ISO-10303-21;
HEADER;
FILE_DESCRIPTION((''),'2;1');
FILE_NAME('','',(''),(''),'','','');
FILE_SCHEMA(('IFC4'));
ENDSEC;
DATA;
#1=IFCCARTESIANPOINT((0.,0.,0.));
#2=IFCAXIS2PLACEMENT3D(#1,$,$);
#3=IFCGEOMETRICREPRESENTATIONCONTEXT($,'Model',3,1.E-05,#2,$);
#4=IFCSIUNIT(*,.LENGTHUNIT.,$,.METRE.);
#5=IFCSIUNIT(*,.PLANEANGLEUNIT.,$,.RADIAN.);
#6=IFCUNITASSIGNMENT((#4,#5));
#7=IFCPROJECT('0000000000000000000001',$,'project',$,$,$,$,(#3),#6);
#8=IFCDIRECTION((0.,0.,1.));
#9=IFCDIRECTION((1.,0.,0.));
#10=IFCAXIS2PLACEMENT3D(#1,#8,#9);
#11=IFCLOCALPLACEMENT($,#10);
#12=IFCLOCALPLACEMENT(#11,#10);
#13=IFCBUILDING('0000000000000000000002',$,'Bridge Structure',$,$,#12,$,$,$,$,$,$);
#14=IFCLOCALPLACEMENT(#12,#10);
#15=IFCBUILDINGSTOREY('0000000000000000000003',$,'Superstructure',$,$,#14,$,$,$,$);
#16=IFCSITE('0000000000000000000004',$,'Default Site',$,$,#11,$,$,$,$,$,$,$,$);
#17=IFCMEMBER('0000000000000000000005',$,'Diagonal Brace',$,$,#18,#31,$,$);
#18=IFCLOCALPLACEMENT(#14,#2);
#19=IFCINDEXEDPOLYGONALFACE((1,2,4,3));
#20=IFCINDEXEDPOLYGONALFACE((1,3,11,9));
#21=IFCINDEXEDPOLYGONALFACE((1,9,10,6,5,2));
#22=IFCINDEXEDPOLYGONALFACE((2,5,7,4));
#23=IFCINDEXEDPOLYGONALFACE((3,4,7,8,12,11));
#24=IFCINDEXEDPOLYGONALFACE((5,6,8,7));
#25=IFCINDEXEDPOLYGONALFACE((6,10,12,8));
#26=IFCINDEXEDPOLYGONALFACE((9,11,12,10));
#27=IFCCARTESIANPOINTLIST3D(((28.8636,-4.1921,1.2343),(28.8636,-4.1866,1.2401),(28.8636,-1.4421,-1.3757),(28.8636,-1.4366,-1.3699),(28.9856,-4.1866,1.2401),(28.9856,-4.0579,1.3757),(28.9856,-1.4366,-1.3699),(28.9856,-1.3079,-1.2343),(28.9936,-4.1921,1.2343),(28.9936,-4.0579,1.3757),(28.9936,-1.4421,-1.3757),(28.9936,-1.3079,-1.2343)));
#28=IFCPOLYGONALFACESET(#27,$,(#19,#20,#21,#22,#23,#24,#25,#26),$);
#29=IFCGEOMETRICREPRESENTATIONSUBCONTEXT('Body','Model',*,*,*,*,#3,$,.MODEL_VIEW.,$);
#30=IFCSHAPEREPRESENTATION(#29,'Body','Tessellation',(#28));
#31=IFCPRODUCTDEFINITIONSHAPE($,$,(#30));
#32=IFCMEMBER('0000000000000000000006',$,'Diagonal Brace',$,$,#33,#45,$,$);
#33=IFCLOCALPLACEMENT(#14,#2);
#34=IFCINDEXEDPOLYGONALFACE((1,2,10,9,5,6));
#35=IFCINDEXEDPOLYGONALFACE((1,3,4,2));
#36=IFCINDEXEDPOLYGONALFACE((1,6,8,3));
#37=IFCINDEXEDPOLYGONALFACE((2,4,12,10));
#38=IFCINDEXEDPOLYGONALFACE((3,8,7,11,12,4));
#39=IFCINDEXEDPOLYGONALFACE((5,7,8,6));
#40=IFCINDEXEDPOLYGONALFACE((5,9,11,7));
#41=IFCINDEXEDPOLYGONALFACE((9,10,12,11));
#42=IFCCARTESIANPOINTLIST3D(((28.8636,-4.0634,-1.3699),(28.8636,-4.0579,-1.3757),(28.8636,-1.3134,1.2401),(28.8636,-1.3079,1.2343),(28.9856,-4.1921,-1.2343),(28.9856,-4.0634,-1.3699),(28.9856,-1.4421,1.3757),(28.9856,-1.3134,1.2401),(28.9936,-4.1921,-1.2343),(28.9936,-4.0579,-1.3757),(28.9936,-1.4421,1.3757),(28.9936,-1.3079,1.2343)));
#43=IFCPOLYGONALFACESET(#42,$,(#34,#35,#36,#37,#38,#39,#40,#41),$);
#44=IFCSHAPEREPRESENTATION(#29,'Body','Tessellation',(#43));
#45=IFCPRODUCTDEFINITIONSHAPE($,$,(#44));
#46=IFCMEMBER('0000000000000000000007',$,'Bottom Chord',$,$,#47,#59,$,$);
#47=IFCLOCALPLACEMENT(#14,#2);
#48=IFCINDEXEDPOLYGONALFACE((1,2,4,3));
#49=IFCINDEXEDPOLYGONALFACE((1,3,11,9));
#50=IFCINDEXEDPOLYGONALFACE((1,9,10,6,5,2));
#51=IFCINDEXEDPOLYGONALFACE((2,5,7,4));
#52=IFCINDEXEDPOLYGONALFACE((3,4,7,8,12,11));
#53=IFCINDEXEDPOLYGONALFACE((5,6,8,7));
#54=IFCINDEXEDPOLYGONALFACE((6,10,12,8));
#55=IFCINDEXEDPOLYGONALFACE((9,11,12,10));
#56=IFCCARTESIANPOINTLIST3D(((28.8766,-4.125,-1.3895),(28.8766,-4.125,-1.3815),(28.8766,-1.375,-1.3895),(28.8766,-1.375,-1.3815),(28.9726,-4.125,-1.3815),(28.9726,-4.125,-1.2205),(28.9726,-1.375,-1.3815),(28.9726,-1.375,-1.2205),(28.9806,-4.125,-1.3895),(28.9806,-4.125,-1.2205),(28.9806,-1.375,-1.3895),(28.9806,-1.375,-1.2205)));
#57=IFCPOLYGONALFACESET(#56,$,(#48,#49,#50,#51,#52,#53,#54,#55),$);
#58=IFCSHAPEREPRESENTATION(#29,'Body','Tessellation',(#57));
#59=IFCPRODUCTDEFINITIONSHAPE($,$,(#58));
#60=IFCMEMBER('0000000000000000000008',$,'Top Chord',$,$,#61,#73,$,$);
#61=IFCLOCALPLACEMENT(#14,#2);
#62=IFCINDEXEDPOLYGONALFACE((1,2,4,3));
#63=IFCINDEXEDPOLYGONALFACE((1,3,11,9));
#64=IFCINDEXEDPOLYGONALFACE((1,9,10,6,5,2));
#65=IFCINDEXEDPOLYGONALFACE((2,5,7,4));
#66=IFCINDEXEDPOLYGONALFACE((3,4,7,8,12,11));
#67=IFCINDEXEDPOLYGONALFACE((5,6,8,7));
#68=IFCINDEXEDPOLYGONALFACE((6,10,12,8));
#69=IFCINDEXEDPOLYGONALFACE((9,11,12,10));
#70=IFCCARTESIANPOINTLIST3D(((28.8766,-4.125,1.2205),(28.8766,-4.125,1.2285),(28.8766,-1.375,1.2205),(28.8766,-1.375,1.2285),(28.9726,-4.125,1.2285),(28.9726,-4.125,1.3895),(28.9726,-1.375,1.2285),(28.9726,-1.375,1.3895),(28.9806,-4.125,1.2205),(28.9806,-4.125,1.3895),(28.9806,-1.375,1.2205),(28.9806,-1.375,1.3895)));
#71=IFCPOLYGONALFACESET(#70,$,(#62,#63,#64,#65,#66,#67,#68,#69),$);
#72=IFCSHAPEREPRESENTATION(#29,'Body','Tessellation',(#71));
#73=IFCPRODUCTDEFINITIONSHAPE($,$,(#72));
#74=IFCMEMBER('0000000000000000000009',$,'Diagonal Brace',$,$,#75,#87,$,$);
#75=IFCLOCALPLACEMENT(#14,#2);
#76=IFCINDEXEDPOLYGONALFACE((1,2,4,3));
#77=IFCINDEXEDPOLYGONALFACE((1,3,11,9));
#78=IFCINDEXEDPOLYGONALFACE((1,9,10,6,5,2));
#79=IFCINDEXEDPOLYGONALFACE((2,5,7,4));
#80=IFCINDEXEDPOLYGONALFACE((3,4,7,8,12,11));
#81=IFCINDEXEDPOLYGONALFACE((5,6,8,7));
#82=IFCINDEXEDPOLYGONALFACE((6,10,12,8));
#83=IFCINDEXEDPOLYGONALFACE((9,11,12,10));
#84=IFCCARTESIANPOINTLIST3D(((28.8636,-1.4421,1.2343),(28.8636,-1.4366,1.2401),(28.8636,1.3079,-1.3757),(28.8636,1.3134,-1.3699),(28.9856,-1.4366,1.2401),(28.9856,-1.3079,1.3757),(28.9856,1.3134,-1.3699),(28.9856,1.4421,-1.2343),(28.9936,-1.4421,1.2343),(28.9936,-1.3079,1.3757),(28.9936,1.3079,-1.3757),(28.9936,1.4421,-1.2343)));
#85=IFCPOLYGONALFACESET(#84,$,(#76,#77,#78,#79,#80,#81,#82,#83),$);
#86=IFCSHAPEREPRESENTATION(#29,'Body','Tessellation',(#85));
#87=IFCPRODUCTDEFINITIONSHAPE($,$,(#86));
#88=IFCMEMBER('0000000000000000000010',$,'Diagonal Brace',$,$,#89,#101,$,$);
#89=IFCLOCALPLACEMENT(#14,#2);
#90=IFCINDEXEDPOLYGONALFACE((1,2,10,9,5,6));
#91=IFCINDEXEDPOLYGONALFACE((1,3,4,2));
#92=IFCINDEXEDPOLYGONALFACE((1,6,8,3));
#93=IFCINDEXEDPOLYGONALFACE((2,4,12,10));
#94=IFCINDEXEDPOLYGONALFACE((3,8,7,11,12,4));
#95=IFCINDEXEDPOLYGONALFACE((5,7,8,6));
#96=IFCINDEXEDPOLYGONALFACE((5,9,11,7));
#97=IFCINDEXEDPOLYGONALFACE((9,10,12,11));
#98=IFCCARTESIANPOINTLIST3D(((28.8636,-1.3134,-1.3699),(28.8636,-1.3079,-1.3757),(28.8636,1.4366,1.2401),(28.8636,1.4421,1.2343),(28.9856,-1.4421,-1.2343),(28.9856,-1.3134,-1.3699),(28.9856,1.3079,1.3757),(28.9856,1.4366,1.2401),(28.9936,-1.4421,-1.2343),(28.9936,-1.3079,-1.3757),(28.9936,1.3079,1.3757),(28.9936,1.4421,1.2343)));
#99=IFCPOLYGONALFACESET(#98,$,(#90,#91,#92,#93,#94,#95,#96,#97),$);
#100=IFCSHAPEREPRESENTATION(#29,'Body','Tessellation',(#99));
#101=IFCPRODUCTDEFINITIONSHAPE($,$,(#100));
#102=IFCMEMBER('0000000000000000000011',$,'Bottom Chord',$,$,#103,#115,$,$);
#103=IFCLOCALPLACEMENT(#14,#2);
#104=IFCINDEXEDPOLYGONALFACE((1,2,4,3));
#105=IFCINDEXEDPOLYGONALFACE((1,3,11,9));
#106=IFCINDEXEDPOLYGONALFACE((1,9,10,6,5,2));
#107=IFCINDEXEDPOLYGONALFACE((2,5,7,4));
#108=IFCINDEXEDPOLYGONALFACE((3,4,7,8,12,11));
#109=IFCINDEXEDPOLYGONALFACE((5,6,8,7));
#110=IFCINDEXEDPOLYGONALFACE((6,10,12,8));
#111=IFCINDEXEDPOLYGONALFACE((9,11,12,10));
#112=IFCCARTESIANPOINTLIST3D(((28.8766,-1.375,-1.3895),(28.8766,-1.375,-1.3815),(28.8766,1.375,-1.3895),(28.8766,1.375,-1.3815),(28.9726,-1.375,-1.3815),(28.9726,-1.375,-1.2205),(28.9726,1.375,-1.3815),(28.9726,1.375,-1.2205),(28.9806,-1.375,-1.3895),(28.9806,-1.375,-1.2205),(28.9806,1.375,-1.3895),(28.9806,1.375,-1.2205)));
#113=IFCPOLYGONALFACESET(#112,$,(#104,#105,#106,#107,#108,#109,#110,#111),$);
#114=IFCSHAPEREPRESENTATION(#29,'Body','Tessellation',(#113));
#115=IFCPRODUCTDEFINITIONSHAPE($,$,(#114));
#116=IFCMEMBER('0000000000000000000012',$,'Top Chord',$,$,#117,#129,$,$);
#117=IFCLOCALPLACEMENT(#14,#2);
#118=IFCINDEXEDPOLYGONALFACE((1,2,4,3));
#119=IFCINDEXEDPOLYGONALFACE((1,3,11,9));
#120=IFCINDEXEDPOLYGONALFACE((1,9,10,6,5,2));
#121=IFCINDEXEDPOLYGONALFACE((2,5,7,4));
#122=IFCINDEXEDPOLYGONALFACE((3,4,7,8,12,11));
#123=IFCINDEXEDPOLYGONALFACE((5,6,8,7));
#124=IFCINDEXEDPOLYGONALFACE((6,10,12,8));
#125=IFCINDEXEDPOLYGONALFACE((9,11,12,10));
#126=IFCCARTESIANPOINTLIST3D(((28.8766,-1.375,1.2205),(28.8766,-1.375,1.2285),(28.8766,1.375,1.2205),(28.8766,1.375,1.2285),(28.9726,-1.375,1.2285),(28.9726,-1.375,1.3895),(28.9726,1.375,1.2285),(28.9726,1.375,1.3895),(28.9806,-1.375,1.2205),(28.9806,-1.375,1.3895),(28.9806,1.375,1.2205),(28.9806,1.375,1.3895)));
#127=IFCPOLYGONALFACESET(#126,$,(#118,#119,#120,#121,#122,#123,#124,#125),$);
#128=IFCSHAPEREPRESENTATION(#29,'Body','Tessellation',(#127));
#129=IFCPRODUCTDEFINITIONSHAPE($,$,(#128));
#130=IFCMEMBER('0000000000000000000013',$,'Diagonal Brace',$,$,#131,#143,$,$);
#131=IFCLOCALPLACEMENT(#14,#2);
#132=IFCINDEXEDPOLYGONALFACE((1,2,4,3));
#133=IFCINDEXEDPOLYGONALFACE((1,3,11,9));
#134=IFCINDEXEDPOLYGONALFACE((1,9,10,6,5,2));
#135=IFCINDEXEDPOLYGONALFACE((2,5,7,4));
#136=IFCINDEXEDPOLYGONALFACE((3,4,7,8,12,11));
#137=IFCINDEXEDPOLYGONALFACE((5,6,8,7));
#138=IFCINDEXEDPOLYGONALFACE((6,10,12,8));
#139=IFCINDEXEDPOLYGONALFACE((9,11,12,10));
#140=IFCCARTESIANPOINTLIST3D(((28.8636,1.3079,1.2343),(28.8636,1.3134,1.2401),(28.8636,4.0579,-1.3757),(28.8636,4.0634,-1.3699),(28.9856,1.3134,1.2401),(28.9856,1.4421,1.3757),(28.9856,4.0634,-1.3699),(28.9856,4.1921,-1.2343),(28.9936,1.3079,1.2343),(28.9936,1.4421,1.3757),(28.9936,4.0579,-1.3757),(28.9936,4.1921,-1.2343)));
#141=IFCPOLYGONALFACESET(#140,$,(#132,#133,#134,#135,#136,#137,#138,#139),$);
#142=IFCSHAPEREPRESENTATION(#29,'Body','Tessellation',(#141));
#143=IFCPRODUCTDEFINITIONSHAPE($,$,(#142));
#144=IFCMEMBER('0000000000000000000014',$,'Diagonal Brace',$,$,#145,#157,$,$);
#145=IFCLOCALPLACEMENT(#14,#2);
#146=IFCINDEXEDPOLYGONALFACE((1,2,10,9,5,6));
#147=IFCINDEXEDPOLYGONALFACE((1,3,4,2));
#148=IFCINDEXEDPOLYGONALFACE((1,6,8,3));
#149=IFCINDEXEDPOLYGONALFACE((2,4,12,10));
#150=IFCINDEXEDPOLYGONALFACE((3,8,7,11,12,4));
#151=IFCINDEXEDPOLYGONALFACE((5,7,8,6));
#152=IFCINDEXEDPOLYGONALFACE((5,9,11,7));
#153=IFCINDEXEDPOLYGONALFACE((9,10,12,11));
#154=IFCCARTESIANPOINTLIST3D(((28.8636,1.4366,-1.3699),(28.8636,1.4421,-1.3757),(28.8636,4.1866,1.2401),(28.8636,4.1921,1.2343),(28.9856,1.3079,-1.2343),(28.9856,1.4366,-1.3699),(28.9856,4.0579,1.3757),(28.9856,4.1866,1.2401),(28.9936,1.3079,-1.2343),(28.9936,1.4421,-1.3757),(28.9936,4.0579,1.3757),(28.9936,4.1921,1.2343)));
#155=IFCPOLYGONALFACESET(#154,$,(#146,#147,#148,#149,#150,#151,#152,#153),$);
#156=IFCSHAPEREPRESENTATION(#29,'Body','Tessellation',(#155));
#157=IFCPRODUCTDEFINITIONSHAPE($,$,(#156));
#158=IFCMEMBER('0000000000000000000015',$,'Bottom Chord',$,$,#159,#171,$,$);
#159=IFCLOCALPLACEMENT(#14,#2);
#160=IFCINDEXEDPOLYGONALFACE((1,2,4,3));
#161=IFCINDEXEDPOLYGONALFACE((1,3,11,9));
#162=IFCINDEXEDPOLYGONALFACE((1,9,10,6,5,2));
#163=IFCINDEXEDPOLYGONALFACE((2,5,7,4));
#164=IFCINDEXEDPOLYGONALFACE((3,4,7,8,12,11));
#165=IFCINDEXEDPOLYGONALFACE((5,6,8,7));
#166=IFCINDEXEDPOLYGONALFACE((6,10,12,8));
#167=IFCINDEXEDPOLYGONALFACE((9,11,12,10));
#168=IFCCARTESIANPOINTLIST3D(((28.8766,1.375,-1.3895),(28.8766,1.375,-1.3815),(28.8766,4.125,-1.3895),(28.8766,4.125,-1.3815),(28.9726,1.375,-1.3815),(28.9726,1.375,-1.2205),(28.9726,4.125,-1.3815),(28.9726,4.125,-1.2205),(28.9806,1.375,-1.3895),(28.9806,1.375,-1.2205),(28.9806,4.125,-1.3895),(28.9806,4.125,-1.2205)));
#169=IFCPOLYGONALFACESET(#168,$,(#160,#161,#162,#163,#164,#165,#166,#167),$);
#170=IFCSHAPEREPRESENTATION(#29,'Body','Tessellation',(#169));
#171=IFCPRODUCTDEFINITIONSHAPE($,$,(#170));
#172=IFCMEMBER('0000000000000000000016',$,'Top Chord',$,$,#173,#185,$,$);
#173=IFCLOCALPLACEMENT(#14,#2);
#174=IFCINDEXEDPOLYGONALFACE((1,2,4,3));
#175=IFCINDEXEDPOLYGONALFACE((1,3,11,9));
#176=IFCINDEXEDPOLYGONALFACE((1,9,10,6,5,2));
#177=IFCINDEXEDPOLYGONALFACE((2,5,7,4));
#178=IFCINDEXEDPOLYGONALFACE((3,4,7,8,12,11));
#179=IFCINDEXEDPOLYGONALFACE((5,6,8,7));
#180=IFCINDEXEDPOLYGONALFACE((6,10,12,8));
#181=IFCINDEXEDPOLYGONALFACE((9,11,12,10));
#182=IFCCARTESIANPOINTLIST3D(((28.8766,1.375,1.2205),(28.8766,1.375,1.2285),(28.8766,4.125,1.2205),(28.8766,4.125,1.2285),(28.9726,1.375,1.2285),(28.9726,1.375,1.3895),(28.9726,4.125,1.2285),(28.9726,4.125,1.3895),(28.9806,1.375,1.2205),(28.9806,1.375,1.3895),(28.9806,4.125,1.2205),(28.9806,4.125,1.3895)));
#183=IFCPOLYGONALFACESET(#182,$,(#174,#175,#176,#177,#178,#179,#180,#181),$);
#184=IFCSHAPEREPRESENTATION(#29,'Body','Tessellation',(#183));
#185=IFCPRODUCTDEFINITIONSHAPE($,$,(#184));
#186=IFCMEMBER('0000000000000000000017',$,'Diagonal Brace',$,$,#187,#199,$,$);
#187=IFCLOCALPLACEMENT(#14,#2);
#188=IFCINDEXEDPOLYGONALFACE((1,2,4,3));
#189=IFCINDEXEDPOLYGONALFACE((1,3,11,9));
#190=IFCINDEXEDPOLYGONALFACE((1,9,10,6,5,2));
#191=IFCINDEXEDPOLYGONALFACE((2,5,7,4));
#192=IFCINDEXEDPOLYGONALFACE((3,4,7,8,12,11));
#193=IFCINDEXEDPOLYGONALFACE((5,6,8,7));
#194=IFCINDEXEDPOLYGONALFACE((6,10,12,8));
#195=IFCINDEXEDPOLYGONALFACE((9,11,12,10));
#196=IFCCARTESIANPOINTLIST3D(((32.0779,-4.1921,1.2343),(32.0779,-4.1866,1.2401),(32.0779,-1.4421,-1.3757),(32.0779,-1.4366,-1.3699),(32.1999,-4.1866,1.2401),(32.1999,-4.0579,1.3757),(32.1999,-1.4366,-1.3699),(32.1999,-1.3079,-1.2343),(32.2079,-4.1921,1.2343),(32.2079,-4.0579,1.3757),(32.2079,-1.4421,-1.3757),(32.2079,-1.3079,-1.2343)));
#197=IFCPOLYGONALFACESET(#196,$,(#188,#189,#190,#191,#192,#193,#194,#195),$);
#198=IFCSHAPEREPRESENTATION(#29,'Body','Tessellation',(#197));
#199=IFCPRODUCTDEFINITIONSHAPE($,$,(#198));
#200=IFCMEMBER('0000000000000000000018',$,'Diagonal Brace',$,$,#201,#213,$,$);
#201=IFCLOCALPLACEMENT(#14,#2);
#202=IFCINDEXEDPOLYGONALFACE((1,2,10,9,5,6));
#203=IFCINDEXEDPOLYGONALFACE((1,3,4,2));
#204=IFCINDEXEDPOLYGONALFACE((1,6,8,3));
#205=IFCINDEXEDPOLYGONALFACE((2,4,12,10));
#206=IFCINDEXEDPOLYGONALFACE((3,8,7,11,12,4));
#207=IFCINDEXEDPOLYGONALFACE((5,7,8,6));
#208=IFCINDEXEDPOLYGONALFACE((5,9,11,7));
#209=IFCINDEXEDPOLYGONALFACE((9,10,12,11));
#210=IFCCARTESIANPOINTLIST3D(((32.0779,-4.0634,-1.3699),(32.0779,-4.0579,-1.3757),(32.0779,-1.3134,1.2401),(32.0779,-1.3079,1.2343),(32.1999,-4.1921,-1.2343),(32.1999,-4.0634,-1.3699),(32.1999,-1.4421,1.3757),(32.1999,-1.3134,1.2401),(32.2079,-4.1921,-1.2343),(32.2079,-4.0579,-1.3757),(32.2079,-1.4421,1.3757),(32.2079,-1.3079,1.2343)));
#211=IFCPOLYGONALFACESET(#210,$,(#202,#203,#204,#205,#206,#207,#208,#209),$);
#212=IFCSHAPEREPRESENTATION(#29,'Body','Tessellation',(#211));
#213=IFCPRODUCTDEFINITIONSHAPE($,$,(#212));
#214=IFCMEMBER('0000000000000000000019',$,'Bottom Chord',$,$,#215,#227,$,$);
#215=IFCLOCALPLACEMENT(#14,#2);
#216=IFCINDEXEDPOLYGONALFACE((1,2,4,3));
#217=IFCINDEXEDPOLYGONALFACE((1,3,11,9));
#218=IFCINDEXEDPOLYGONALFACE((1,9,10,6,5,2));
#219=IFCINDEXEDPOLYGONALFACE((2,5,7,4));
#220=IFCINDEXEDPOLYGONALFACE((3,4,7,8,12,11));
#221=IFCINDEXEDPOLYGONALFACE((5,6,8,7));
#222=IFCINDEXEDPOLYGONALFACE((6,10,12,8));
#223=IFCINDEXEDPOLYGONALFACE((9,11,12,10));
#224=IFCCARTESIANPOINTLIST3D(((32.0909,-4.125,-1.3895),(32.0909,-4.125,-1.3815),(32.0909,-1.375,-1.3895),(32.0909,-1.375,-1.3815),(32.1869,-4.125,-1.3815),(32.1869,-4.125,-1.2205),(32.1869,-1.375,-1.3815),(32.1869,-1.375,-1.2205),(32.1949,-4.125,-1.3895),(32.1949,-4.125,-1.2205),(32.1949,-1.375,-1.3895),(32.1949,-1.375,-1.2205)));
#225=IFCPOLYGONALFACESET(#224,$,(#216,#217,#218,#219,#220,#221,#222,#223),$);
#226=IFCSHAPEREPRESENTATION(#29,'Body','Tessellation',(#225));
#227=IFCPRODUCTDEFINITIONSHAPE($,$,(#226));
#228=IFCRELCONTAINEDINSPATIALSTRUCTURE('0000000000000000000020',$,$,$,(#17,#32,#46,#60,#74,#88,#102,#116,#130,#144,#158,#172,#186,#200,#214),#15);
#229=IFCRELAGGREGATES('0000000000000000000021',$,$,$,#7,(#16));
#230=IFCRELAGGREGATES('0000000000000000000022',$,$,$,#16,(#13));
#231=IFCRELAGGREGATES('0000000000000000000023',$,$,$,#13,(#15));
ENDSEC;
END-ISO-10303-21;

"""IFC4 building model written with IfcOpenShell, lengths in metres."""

from ifc_helpers import new_model, si_unit, frame, origin, origin_with_axes, origin_2d_with_axis, place, context, subcontext, project, spatial, l_section, extrude, element, save


model = new_model("IFC4")

# Units and contexts
model_context = context("Model", 3, precision=1e-05, world=origin())
body_context = subcontext(model_context, "Body", "Model", "MODEL_VIEW")
ifc_project = project(units=[si_unit("LENGTHUNIT", "METRE"), si_unit("PLANEANGLEUNIT", "RADIAN")], contexts=[model_context])

# Site, building, storey
site_placement = place(None, origin_with_axes())
site = spatial("IfcSite", under=ifc_project, at=site_placement, Name="Default Site")
building_placement = place(site_placement, origin_with_axes())
building = spatial("IfcBuilding", under=site, at=building_placement, Name="Bridge Structure")
storey_placement = place(building_placement, origin_with_axes())
storey = spatial("IfcBuildingStorey", under=building, at=storey_placement, Name="Superstructure")

# Members
for number, where, z_axis, x_axis, name in (
    (1, (28.9286, -4.125, 1.305), (0.0, 0.725329, -0.688403), (-1.0, 0.0, 0.0), "Diagonal Brace"),
    (2, (28.9286, -4.125, -1.305), (0.0, 0.725329, 0.688403), (-1.0, 0.0, 0.0), "Diagonal Brace"),
):
    element("IfcMember", number, at=place(storey_placement, frame(where, z_axis=z_axis, x_axis=x_axis)), inside=storey, Name=name, context=body_context, shape_type="SweptSolid", body=[
        extrude(l_section(Depth=0.195, Width=0.13, Thickness=0.008, at=origin_2d_with_axis()), origin_with_axes(), (0.0, 0.0, 1.0), 3.7914),
    ])
for number, where, z_axis, x_axis, name in (
    (3, (28.9286, -4.125, -1.305), (0.0, 1.0, 0.0), (-1.0, 0.0, 0.0), "Bottom Chord"),
    (4, (28.9286, -4.125, 1.305), (0.0, 1.0, 0.0), (-1.0, 0.0, 0.0), "Top Chord"),
):
    element("IfcMember", number, at=place(storey_placement, frame(where, z_axis=z_axis, x_axis=x_axis)), inside=storey, Name=name, context=body_context, shape_type="SweptSolid", body=[
        extrude(l_section(Depth=0.169, Width=0.104, Thickness=0.008, at=origin_2d_with_axis()), origin_with_axes(), (0.0, 0.0, 1.0), 2.75),
    ])
for number, where, z_axis, x_axis, name in (
    (5, (28.9286, -1.375, 1.305), (0.0, 0.725329, -0.688403), (-1.0, 0.0, 0.0), "Diagonal Brace"),
    (6, (28.9286, -1.375, -1.305), (0.0, 0.725329, 0.688403), (-1.0, 0.0, 0.0), "Diagonal Brace"),
):
    element("IfcMember", number, at=place(storey_placement, frame(where, z_axis=z_axis, x_axis=x_axis)), inside=storey, Name=name, context=body_context, shape_type="SweptSolid", body=[
        extrude(l_section(Depth=0.195, Width=0.13, Thickness=0.008, at=origin_2d_with_axis()), origin_with_axes(), (0.0, 0.0, 1.0), 3.7914),
    ])
for number, where, z_axis, x_axis, name in (
    (7, (28.9286, -1.375, -1.305), (0.0, 1.0, 0.0), (-1.0, 0.0, 0.0), "Bottom Chord"),
    (8, (28.9286, -1.375, 1.305), (0.0, 1.0, 0.0), (-1.0, 0.0, 0.0), "Top Chord"),
):
    element("IfcMember", number, at=place(storey_placement, frame(where, z_axis=z_axis, x_axis=x_axis)), inside=storey, Name=name, context=body_context, shape_type="SweptSolid", body=[
        extrude(l_section(Depth=0.169, Width=0.104, Thickness=0.008, at=origin_2d_with_axis()), origin_with_axes(), (0.0, 0.0, 1.0), 2.75),
    ])
for number, where, z_axis, x_axis, name in (
    (9, (28.9286, 1.375, 1.305), (0.0, 0.725329, -0.688403), (-1.0, 0.0, 0.0), "Diagonal Brace"),
    (10, (28.9286, 1.375, -1.305), (0.0, 0.725329, 0.688403), (-1.0, 0.0, 0.0), "Diagonal Brace"),
):
    element("IfcMember", number, at=place(storey_placement, frame(where, z_axis=z_axis, x_axis=x_axis)), inside=storey, Name=name, context=body_context, shape_type="SweptSolid", body=[
        extrude(l_section(Depth=0.195, Width=0.13, Thickness=0.008, at=origin_2d_with_axis()), origin_with_axes(), (0.0, 0.0, 1.0), 3.7914),
    ])
for number, where, z_axis, x_axis, name in (
    (11, (28.9286, 1.375, -1.305), (0.0, 1.0, 0.0), (-1.0, 0.0, 0.0), "Bottom Chord"),
    (12, (28.9286, 1.375, 1.305), (0.0, 1.0, 0.0), (-1.0, 0.0, 0.0), "Top Chord"),
):
    element("IfcMember", number, at=place(storey_placement, frame(where, z_axis=z_axis, x_axis=x_axis)), inside=storey, Name=name, context=body_context, shape_type="SweptSolid", body=[
        extrude(l_section(Depth=0.169, Width=0.104, Thickness=0.008, at=origin_2d_with_axis()), origin_with_axes(), (0.0, 0.0, 1.0), 2.75),
    ])
for number, where, z_axis, x_axis, name in (
    (13, (32.1429, -4.125, 1.305), (0.0, 0.725329, -0.688403), (-1.0, 0.0, 0.0), "Diagonal Brace"),
    (14, (32.1429, -4.125, -1.305), (0.0, 0.725329, 0.688403), (-1.0, 0.0, 0.0), "Diagonal Brace"),
):
    element("IfcMember", number, at=place(storey_placement, frame(where, z_axis=z_axis, x_axis=x_axis)), inside=storey, Name=name, context=body_context, shape_type="SweptSolid", body=[
        extrude(l_section(Depth=0.195, Width=0.13, Thickness=0.008, at=origin_2d_with_axis()), origin_with_axes(), (0.0, 0.0, 1.0), 3.7914),
    ])
for number, where, z_axis, x_axis, name in (
    (15, (32.1429, -4.125, -1.305), (0.0, 1.0, 0.0), (-1.0, 0.0, 0.0), "Bottom Chord"),
):
    element("IfcMember", number, at=place(storey_placement, frame(where, z_axis=z_axis, x_axis=x_axis)), inside=storey, Name=name, context=body_context, shape_type="SweptSolid", body=[
        extrude(l_section(Depth=0.169, Width=0.104, Thickness=0.008, at=origin_2d_with_axis()), origin_with_axes(), (0.0, 0.0, 1.0), 2.75),
    ])

save(model, "model.ifc")
